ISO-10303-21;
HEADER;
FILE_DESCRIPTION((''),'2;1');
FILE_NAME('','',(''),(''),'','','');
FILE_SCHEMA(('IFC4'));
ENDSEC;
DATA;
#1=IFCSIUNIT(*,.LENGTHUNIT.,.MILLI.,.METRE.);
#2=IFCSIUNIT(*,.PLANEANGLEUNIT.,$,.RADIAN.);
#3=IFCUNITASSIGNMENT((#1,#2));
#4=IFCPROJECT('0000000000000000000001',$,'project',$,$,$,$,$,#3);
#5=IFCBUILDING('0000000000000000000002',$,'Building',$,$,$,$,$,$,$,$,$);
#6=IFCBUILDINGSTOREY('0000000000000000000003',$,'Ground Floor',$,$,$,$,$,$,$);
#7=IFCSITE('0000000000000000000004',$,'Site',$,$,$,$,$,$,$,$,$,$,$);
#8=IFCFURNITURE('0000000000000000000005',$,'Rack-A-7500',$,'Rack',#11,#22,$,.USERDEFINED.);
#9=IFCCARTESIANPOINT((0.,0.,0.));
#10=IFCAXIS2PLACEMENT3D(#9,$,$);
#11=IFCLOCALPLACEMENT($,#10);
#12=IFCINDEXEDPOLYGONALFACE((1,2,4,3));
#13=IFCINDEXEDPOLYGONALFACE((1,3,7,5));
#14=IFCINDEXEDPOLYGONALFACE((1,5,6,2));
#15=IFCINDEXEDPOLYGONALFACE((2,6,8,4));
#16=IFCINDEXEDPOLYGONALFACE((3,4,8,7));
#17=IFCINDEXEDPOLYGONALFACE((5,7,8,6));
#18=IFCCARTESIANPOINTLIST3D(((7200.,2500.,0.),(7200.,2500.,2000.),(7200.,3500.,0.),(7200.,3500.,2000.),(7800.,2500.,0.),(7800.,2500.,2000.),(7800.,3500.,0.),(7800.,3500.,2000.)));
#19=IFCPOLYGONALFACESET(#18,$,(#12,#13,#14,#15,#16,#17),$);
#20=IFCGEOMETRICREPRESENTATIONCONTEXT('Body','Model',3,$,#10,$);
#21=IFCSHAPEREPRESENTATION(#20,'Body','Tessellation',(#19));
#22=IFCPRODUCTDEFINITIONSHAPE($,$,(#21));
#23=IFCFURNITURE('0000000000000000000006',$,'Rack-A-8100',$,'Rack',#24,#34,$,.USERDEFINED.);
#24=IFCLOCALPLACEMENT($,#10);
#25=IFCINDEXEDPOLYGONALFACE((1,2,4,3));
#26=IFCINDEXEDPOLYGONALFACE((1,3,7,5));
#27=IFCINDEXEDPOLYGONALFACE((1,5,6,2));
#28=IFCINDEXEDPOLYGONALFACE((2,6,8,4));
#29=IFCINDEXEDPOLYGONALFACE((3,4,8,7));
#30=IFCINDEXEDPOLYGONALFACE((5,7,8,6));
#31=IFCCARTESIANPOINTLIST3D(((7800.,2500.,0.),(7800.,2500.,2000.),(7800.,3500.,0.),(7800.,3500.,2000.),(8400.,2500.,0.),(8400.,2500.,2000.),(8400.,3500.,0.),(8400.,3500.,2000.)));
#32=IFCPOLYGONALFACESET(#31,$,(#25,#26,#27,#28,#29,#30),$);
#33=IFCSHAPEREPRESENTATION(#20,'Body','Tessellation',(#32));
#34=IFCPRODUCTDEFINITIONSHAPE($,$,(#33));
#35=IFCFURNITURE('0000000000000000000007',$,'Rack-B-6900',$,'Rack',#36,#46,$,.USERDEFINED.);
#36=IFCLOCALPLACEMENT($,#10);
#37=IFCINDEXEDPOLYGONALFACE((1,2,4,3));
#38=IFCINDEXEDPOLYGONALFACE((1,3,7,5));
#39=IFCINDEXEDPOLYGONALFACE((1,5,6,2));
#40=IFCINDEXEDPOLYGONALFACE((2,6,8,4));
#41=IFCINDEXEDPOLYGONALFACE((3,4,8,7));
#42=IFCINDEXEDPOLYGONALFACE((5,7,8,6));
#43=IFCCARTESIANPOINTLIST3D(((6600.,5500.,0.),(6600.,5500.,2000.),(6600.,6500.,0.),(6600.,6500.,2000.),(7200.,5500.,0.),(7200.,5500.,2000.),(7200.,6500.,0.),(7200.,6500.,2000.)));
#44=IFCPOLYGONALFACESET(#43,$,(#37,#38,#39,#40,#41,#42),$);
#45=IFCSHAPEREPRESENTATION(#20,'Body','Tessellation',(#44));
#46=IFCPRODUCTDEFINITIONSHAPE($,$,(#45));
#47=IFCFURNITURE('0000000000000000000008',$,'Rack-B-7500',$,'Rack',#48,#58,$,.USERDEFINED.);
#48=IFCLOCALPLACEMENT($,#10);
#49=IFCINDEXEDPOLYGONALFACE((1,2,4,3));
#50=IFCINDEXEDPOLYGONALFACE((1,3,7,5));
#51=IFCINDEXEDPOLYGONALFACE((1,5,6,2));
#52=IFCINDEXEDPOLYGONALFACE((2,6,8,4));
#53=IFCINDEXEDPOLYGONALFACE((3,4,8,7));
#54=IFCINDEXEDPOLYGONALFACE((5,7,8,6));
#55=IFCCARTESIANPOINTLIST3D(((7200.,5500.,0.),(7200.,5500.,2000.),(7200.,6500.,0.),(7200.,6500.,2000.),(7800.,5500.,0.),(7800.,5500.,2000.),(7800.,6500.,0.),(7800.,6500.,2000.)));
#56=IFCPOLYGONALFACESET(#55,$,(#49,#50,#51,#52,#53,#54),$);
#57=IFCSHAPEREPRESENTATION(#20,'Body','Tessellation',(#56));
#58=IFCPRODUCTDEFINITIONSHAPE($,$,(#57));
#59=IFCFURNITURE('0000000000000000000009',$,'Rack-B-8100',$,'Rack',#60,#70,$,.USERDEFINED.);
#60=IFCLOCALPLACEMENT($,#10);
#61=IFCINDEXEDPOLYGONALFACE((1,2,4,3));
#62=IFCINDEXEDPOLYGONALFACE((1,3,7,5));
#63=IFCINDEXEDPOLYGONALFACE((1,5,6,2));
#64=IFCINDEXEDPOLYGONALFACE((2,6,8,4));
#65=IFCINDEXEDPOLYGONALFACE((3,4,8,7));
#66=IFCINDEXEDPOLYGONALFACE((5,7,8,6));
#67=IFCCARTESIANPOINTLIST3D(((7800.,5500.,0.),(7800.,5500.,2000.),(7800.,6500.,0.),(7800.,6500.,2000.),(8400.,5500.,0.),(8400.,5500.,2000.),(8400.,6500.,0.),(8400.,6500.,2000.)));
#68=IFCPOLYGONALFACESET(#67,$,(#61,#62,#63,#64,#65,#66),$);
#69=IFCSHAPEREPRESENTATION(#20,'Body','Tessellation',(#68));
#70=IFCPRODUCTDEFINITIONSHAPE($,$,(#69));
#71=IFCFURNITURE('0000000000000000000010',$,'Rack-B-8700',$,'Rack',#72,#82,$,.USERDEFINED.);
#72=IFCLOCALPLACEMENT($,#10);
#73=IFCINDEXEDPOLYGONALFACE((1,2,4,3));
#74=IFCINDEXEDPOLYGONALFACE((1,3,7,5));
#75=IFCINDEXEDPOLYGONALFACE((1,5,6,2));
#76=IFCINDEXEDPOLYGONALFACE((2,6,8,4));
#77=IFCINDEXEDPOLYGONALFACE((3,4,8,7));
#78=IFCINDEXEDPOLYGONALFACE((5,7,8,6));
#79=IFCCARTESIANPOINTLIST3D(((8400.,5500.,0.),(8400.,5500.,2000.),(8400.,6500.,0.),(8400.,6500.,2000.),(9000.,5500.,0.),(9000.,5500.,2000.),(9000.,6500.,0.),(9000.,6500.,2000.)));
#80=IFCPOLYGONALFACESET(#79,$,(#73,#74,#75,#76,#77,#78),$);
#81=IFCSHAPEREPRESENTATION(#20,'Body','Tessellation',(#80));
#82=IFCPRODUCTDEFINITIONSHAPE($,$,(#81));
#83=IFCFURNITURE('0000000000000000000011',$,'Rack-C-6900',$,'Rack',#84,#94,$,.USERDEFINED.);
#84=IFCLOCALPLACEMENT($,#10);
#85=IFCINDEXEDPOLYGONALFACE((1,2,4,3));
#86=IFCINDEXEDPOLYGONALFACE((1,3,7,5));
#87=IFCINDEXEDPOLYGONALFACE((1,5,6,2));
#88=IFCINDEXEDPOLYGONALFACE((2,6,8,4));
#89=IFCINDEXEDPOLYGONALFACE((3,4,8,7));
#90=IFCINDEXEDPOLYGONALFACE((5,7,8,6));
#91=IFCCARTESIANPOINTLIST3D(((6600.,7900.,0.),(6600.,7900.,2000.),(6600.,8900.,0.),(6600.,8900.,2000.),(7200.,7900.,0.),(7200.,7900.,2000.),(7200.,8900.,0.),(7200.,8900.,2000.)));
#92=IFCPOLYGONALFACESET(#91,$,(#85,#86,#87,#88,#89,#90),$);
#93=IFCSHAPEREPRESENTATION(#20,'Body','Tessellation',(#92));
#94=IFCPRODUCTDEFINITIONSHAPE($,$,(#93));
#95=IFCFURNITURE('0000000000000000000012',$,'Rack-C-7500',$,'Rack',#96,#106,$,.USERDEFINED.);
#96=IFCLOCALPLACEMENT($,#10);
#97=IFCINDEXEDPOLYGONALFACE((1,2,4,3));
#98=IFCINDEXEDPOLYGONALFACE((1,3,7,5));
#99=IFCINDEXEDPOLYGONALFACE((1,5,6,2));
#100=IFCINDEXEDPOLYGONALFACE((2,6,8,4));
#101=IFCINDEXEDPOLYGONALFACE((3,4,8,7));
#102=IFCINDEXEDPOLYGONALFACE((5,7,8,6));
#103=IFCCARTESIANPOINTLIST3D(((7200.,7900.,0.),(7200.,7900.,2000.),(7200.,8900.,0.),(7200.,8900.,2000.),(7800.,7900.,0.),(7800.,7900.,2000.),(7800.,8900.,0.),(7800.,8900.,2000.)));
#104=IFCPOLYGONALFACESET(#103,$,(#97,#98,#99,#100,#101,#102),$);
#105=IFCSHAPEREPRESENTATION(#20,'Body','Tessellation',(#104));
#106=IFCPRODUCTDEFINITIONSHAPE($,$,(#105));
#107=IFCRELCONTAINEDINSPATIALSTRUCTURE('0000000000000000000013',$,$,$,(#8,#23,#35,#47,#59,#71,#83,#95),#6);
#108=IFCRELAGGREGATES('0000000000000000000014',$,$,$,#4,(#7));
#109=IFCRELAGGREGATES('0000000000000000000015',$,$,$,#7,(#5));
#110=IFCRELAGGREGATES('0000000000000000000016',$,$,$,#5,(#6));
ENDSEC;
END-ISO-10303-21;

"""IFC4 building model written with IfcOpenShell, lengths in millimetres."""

from ifc_helpers import new_model, si_unit, frame, origin, place, context, project, spatial, rectangle, extrude, element, save


model = new_model("IFC4")

# Units and contexts
model_context = context("Model", 3, world=origin(), identifier="Body")
ifc_project = project(units=[si_unit("LENGTHUNIT", "METRE", prefix="MILLI"), si_unit("PLANEANGLEUNIT", "RADIAN")])

# Site, building, storey
site = spatial("IfcSite", under=ifc_project, Name="Site")
building = spatial("IfcBuilding", under=site, Name="Building")
storey = spatial("IfcBuildingStorey", under=building, Name="Ground Floor")

# Furniture
for number, where, z_axis, x_axis, name in (
    (1, (7500.0, 3000.0, 0.0), (0.0, 0.0, 1.0), (1.0, 0.0, 0.0), "Rack-A-7500"),
    (2, (8100.0, 3000.0, 0.0), (0.0, 0.0, 1.0), (1.0, 0.0, 0.0), "Rack-A-8100"),
    (3, (6900.0, 6000.0, 0.0), (0.0, 0.0, 1.0), (1.0, 0.0, 0.0), "Rack-B-6900"),
    (4, (7500.0, 6000.0, 0.0), (0.0, 0.0, 1.0), (1.0, 0.0, 0.0), "Rack-B-7500"),
    (5, (8100.0, 6000.0, 0.0), (0.0, 0.0, 1.0), (1.0, 0.0, 0.0), "Rack-B-8100"),
    (6, (8700.0, 6000.0, 0.0), (0.0, 0.0, 1.0), (1.0, 0.0, 0.0), "Rack-B-8700"),
    (7, (6900.0, 8400.0, 0.0), (0.0, 0.0, 1.0), (1.0, 0.0, 0.0), "Rack-C-6900"),
    (8, (7500.0, 8400.0, 0.0), (0.0, 0.0, 1.0), (1.0, 0.0, 0.0), "Rack-C-7500"),
):
    element("IfcFurniture", number, at=place(None, frame(where, z_axis=z_axis, x_axis=x_axis)), inside=storey, Name=name, ObjectType="Rack", PredefinedType="USERDEFINED", context=model_context, shape_type="SweptSolid", body=[
        extrude(rectangle(XDim=600.0, YDim=1000.0), origin(), (0.0, 0.0, 1.0), 2000.0),
    ])

save(model, "model.ifc")
